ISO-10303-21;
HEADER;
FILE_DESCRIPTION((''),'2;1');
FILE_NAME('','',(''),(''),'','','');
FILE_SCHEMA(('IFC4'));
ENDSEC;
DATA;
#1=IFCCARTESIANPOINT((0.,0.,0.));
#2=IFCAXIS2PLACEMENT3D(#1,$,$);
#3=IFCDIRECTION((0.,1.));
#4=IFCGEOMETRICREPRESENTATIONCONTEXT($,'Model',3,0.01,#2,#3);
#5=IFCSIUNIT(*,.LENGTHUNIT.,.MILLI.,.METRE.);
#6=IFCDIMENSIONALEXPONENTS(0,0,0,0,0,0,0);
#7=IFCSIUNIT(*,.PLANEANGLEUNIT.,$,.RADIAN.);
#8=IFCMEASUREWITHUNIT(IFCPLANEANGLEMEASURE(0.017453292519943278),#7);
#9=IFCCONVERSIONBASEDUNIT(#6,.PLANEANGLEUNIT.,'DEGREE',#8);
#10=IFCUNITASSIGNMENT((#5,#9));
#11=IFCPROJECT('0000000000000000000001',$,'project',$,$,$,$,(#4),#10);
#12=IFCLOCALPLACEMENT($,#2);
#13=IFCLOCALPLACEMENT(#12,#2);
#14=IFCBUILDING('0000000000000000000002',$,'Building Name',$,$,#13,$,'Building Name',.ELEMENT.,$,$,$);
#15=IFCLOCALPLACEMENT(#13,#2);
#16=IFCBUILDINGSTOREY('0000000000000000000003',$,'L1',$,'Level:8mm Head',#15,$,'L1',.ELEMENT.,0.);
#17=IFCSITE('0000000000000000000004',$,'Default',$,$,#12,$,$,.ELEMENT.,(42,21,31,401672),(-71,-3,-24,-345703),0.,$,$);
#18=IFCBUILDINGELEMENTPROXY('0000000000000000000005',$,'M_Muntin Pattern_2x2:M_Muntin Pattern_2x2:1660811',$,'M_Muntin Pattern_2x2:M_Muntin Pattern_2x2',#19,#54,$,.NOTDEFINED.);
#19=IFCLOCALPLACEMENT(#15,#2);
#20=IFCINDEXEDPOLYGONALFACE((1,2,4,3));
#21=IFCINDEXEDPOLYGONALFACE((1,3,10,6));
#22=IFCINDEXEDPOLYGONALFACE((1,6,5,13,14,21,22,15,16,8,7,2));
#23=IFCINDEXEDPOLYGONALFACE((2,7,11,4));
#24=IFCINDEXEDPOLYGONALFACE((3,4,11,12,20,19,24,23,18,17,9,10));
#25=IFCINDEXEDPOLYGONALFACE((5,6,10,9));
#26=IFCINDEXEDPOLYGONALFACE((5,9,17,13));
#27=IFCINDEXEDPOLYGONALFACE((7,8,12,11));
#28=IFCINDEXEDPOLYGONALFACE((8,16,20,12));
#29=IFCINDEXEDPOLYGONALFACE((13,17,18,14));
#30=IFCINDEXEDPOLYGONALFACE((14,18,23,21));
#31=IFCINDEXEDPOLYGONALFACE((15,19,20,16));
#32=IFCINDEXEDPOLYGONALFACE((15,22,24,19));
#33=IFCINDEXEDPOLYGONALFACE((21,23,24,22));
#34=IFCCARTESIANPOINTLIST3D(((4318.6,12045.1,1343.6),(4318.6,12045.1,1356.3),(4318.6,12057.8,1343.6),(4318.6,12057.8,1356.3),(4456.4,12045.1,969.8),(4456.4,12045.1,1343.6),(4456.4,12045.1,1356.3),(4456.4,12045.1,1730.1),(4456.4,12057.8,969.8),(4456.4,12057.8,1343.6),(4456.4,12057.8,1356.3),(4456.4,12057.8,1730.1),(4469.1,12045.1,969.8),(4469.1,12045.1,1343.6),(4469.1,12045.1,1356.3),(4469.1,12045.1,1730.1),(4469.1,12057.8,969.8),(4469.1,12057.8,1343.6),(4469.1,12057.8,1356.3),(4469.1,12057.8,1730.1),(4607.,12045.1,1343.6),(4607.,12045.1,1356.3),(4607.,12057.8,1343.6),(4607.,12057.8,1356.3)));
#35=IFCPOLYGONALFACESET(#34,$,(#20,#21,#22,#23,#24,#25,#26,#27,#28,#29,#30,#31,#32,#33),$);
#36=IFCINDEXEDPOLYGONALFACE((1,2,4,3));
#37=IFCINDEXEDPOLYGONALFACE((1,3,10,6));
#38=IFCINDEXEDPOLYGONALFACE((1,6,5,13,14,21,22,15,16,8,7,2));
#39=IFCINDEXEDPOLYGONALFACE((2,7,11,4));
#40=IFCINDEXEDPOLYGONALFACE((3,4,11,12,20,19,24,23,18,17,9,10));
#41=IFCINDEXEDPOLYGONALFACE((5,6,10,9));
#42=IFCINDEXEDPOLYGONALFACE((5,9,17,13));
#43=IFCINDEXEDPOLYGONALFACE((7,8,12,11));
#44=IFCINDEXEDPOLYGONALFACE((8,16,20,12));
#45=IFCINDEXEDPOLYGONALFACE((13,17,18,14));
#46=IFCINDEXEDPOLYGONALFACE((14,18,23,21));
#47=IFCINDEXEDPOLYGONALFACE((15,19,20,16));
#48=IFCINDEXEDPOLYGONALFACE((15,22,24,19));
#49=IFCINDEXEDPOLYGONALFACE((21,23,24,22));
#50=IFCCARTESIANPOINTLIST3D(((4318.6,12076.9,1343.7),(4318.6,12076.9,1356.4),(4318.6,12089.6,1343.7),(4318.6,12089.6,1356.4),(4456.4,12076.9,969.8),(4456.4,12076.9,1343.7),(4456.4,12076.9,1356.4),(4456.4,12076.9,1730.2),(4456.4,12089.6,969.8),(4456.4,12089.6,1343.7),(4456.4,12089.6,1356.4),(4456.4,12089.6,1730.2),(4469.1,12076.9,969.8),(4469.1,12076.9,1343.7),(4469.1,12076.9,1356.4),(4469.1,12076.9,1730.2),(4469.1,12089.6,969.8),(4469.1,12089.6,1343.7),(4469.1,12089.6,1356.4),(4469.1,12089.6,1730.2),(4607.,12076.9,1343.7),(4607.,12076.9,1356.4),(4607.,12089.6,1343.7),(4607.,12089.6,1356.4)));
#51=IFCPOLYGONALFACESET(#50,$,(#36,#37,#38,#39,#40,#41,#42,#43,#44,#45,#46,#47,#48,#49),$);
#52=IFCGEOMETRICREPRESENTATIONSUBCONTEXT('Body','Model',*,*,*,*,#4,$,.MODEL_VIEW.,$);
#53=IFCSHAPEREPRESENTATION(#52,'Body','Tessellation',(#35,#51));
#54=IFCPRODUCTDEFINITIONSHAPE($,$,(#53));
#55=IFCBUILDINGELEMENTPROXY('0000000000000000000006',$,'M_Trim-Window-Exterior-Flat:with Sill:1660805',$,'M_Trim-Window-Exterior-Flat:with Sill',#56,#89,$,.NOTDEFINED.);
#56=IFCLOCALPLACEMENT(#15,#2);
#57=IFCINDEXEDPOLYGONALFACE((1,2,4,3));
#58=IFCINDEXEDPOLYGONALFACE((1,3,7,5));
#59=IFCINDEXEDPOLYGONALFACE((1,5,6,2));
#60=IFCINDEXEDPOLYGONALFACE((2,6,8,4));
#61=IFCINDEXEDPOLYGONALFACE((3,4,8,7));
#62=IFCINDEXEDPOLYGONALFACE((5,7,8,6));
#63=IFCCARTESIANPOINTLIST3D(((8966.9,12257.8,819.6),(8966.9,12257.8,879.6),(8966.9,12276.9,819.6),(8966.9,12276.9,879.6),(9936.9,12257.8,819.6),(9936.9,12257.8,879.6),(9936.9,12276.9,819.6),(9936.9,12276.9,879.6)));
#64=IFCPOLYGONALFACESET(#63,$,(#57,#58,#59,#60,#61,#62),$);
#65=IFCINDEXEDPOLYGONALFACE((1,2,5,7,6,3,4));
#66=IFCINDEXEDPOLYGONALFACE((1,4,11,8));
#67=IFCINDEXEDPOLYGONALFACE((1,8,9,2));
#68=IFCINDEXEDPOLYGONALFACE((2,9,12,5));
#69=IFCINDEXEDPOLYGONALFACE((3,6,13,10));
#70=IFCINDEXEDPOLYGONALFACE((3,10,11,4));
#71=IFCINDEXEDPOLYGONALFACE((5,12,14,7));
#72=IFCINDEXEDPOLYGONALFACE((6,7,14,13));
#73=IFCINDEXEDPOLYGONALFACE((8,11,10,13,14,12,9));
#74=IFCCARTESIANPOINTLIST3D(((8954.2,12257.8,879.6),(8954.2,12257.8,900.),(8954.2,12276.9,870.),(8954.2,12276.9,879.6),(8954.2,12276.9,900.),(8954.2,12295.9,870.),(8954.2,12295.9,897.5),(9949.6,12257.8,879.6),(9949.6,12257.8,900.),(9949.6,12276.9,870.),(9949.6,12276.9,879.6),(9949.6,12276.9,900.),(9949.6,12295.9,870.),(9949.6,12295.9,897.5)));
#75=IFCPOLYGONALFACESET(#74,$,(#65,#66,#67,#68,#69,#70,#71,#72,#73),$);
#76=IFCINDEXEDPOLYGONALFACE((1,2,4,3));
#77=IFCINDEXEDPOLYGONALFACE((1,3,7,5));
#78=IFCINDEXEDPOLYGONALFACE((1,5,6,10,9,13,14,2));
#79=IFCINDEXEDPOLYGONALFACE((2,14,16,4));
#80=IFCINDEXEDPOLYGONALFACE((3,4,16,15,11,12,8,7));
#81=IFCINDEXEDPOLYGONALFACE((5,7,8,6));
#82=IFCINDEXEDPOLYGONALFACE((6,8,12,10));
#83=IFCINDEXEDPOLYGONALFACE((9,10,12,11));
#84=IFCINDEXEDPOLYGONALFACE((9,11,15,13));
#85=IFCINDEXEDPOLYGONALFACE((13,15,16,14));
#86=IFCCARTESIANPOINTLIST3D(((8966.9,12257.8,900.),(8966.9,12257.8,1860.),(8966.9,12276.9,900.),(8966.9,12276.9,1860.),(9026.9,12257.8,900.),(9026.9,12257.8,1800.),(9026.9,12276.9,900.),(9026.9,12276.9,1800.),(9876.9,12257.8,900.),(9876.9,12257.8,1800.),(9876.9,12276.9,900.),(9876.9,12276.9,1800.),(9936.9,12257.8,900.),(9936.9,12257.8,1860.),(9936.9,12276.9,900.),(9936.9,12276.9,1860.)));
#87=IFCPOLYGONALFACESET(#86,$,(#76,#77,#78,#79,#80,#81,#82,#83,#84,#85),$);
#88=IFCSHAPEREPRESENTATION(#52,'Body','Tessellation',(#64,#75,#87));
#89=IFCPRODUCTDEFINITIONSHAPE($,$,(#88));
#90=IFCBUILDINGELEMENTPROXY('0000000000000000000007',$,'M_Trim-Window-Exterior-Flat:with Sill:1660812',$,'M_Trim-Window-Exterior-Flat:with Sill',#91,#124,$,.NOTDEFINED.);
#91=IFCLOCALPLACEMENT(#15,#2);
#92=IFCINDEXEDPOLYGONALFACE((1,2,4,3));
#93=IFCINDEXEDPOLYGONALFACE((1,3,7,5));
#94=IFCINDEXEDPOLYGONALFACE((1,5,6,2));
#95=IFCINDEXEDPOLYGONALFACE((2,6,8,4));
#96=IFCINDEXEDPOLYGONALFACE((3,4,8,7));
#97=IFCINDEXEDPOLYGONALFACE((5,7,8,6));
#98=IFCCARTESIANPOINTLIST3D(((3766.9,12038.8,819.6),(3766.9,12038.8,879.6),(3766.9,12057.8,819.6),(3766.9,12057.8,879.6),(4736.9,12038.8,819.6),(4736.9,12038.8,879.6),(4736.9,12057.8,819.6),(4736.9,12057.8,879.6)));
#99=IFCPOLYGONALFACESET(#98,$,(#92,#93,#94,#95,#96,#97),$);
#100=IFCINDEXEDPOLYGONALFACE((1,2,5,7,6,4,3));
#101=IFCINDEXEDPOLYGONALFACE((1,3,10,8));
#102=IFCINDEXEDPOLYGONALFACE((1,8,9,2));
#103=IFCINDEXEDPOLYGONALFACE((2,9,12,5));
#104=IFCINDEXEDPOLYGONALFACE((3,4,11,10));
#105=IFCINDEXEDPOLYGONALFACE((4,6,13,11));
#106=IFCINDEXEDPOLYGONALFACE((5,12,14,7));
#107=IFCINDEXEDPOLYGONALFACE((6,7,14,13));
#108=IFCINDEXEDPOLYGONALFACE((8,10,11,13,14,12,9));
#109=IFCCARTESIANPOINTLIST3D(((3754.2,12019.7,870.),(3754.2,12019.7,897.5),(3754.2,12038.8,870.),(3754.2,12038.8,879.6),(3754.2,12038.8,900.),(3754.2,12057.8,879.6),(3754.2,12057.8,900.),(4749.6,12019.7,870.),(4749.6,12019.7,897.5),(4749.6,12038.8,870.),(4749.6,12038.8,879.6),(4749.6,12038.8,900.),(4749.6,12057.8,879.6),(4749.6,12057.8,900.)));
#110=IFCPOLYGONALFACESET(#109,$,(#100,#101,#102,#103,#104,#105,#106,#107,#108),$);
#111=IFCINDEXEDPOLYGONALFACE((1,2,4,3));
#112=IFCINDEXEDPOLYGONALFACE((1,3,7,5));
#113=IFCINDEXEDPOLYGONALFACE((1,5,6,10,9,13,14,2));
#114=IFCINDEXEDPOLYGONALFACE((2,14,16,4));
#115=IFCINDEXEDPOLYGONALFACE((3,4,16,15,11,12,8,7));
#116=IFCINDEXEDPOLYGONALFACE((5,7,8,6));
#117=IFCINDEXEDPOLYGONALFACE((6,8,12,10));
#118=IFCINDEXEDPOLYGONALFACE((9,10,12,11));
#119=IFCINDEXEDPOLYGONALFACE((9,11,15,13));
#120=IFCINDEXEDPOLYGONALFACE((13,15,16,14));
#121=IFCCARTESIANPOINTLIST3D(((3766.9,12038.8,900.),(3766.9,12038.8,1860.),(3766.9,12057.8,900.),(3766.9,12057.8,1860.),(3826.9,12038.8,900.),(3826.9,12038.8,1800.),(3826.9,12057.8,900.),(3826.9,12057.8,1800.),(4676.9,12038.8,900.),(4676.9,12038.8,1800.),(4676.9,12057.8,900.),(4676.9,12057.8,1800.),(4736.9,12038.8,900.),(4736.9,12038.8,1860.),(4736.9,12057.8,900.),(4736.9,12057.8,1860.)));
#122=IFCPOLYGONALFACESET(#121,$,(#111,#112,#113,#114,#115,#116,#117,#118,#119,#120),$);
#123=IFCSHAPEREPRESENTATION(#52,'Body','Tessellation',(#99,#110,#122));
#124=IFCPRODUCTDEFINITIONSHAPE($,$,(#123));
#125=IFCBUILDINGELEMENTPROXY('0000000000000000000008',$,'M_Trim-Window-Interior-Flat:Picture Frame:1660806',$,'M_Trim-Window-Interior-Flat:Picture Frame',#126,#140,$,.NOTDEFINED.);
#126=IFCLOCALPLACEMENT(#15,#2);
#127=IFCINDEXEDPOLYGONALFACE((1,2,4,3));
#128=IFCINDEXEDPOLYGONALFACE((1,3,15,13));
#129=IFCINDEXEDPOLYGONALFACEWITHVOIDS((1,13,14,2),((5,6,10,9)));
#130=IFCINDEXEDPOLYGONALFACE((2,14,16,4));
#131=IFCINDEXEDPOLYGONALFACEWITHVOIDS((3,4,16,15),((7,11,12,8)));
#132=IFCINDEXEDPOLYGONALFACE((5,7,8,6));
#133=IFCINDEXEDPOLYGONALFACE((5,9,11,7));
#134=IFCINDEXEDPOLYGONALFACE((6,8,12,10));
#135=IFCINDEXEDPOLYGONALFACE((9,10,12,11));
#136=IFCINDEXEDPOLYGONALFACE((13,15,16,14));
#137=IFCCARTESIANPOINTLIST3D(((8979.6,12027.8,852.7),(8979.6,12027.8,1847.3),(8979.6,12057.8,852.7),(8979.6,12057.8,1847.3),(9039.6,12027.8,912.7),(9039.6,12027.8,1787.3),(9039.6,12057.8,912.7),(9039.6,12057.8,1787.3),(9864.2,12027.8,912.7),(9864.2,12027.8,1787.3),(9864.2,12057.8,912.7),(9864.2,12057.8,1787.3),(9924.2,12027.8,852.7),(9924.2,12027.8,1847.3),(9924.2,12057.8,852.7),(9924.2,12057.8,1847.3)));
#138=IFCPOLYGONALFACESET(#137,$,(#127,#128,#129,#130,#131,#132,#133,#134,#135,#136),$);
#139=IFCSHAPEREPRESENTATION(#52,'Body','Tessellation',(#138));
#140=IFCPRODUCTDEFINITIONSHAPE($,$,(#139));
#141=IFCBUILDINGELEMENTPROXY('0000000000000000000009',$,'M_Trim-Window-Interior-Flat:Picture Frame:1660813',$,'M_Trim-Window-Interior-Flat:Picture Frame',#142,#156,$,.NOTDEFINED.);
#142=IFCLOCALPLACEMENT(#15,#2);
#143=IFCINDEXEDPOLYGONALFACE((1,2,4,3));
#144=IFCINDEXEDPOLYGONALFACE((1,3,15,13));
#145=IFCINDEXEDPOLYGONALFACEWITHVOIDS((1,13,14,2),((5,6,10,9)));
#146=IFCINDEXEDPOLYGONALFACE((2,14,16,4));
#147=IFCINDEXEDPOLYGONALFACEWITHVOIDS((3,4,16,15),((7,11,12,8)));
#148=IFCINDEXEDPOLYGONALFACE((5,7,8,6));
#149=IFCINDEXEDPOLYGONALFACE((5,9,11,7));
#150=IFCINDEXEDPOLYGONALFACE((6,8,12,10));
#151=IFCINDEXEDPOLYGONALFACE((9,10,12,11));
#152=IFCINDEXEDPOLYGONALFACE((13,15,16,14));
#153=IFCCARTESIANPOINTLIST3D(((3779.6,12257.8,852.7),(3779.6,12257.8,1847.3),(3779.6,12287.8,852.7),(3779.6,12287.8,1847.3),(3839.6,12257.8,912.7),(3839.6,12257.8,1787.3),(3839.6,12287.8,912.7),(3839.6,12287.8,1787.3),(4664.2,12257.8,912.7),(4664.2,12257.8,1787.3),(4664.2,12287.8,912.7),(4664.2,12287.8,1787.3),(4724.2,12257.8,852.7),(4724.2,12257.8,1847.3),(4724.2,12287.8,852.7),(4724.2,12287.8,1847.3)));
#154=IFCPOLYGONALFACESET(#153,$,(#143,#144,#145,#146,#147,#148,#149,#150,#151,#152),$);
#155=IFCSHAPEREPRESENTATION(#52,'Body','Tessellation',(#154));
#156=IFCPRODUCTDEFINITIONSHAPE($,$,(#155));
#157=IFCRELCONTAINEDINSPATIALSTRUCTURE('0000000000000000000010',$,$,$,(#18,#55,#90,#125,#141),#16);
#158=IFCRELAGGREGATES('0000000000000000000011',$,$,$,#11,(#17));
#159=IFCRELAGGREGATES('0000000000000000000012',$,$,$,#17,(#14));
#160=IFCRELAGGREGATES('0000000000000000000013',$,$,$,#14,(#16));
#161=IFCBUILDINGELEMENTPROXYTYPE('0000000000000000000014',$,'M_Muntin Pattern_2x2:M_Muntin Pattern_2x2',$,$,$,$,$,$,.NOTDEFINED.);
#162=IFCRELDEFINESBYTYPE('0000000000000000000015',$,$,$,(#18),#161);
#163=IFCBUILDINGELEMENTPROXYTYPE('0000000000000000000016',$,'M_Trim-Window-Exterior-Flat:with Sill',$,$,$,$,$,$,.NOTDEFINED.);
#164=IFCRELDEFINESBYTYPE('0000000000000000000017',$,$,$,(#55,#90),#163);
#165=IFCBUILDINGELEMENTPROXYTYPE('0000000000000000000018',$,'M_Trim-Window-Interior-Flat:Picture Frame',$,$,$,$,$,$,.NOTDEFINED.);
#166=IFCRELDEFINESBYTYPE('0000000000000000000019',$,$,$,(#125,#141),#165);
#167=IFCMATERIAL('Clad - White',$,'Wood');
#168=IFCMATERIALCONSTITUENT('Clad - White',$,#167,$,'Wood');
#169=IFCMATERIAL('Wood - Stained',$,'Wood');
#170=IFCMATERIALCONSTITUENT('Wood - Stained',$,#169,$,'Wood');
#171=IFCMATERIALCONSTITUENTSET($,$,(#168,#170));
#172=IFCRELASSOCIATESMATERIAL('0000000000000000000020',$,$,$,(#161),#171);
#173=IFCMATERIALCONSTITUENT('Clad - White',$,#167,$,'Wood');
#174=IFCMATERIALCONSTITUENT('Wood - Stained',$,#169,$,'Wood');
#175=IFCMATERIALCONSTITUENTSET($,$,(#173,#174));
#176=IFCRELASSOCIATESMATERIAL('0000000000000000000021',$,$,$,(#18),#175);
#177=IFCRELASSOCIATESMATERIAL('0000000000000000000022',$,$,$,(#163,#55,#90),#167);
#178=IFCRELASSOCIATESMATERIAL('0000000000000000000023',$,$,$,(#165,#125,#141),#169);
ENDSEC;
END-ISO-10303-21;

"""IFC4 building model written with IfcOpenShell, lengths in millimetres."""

from ifc_helpers import new_model, entity, si_unit, converted_unit, direction, frame, origin, place, context, subcontext, project, spatial, indexed_curve, outline, extrude, source, transform, mapped, material, constituent, constituent_set, type_object, type_shapes, element, save


model = new_model("IFC4")

# Units and contexts
model_context = context("Model", 3, precision=0.01, world=origin(), true_north=direction((0.0, 1.0)))
body_context = subcontext(model_context, "Body", "Model", "MODEL_VIEW")
ifc_project = project(units=[si_unit("LENGTHUNIT", "METRE", prefix="MILLI"), converted_unit("PLANEANGLEUNIT", "DEGREE", entity("IfcPlaneAngleMeasure", 0.017453292519943278), si_unit("PLANEANGLEUNIT", "RADIAN"), dimensions=[0, 0, 0, 0, 0, 0, 0])], contexts=[model_context])

# Site, building, storey
site_placement = place(None, origin())
site = spatial("IfcSite", under=ifc_project, at=site_placement, Name="Default", CompositionType="ELEMENT", RefLatitude=(42, 21, 31, 401672), RefLongitude=(-71, -3, -24, -345703), RefElevation=0.0)
building_placement = place(site_placement, origin())
building = spatial("IfcBuilding", under=site, at=building_placement, Name="Building Name", LongName="Building Name", CompositionType="ELEMENT")
storey_placement = place(building_placement, origin())
storey = spatial("IfcBuildingStorey", under=building, at=storey_placement, Name="L1", ObjectType="Level:8mm Head", LongName="L1", CompositionType="ELEMENT", Elevation=0.0)

# Building element proxies
ifc_material_1 = material(Name="Clad - White", Category="Wood")
ifc_material_2 = material(Name="Wood - Stained", Category="Wood")
ifc_constituent_1 = constituent(ifc_material_1, Name="Clad - White", Category="Wood")
ifc_constituent_2 = constituent(ifc_material_2, Name="Wood - Stained", Category="Wood")
ifc_constituent_set_1 = constituent_set(constituents=[ifc_constituent_1, ifc_constituent_2])
building_element_proxy_type_1 = type_object("IfcBuildingElementProxyType", Name="M_Muntin Pattern_2x2:M_Muntin Pattern_2x2", PredefinedType="NOTDEFINED", material=ifc_constituent_set_1)
shared_shape_1 = source(origin(), body_context, "Body", "SweptSolid", [
    extrude(outline(indexed_curve([(6.4, -6.4), (380.1, -6.4), (380.1, 6.3), (6.4, 6.3), (6.4, 144.2), (-6.3, 144.2), (-6.3, 6.3), (-380.2, 6.3), (-380.2, -6.4), (-6.3, -6.4), (-6.3, -144.2), (6.4, -144.2), (6.4, -6.4)], self_intersect=False)), frame((0.0, 9.5, 380.1), z_axis=(0.0, 1.0, 0.0), x_axis=(0.0, 0.0, 1.0)), (0.0, 0.0, 1.0), 12.7),
    extrude(outline(indexed_curve([(6.4, -6.4), (380.2, -6.4), (380.2, 6.3), (6.4, 6.3), (6.4, 144.2), (-6.3, 144.2), (-6.3, 6.3), (-380.2, 6.3), (-380.2, -6.4), (-6.3, -6.4), (-6.3, -144.2), (6.4, -144.2), (6.4, -6.4)], self_intersect=False)), frame((0.0, -22.2, 380.2), z_axis=(0.0, 1.0, 0.0), x_axis=(0.0, 0.0, 1.0)), (0.0, 0.0, 1.0), 12.7),
])
type_shapes(building_element_proxy_type_1, [shared_shape_1])
ifc_constituent_3 = constituent(ifc_material_1, Name="Clad - White", Category="Wood")
ifc_constituent_4 = constituent(ifc_material_2, Name="Wood - Stained", Category="Wood")
ifc_constituent_set_2 = constituent_set(constituents=[ifc_constituent_3, ifc_constituent_4])
proxy_1_placement = place(storey_placement, frame((4462.8, 12067.3, 969.8), z_axis=(0.0, 0.0, 1.0), x_axis=(-1.0, 0.0, 0.0)))
element("IfcBuildingElementProxy", 1, at=proxy_1_placement, inside=storey, type_object=building_element_proxy_type_1, material=ifc_constituent_set_2, Name="M_Muntin Pattern_2x2:M_Muntin Pattern_2x2:1660811", ObjectType="M_Muntin Pattern_2x2:M_Muntin Pattern_2x2", PredefinedType="NOTDEFINED", context=body_context, shape_type="MappedRepresentation", body=[
    mapped(shared_shape_1, transform((0.0, 0.0, 0.0), scale=1.0)),
])
building_element_proxy_type_2 = type_object("IfcBuildingElementProxyType", Name="M_Trim-Window-Exterior-Flat:with Sill", PredefinedType="NOTDEFINED", material=ifc_material_1)
shared_shape_2 = source(origin(), body_context, "Body", "SweptSolid", [
    extrude(outline(indexed_curve([(-485.0, -30.0), (485.0, -30.0), (485.0, 30.0), (-485.0, 30.0), (-485.0, -30.0)], self_intersect=False)), frame((0.0, -950.4, 0.0), z_axis=(0.0, 0.0, 1.0), x_axis=(-1.0, 0.0, 0.0)), (0.0, 0.0, 1.0), 19.0),
    extrude(outline(indexed_curve([(-19.0, -15.2), (0.0, -15.2), (0.0, -5.7), (19.0, -5.7), (19.0, 14.8), (0.0, 14.8), (-19.0, 12.3), (-19.0, -15.2)], self_intersect=False)), frame((-497.7, -914.8, 19.0), z_axis=(1.0, 0.0, 0.0), x_axis=(0.0, 0.0, -1.0)), (0.0, 0.0, 1.0), 995.4),
    extrude(outline(indexed_curve([(-495.0, -485.0), (465.0, -485.0), (465.0, -425.0), (-435.0, -425.0), (-435.0, 425.0), (465.0, 425.0), (465.0, 485.0), (-495.0, 485.0), (-495.0, -485.0)], self_intersect=False)), frame((0.0, -435.0, 0.0), z_axis=(0.0, 0.0, 1.0), x_axis=(0.0, -1.0, 0.0)), (0.0, 0.0, 1.0), 19.0),
])
type_shapes(building_element_proxy_type_2, [shared_shape_2])
for number, where, z_axis, x_axis, name in (
    (2, (9451.9, 12257.8, 1800.0), (0.0, 1.0, 0.0), (-1.0, 0.0, 0.0), "M_Trim-Window-Exterior-Flat:with Sill:1660805"),
    (3, (4251.9, 12057.8, 1800.0), (0.0, -1.0, 0.0), (1.0, 0.0, 0.0), "M_Trim-Window-Exterior-Flat:with Sill:1660812"),
):
    element("IfcBuildingElementProxy", number, at=place(storey_placement, frame(where, z_axis=z_axis, x_axis=x_axis)), inside=storey, type_object=building_element_proxy_type_2, material=ifc_material_1, Name=name, ObjectType="M_Trim-Window-Exterior-Flat:with Sill", PredefinedType="NOTDEFINED", context=body_context, shape_type="MappedRepresentation", body=[
        mapped(shared_shape_2, transform((0.0, 0.0, 0.0), scale=1.0)),
    ])
building_element_proxy_type_3 = type_object("IfcBuildingElementProxyType", Name="M_Trim-Window-Interior-Flat:Picture Frame", PredefinedType="NOTDEFINED", material=ifc_material_2)
shared_shape_3 = source(origin(), body_context, "Body", "SweptSolid", [
    extrude(outline(indexed_curve([(-472.3, -497.3), (472.3, -497.3), (472.3, 497.3), (-472.3, 497.3), (-472.3, -497.3)], self_intersect=False), holes=[indexed_curve([(-412.3, -437.3), (-412.3, 437.3), (412.3, 437.3), (412.3, -437.3), (-412.3, -437.3)], self_intersect=False)]), frame((0.0, -450.0, 0.0), z_axis=(0.0, 0.0, 1.0), x_axis=(-1.0, 0.0, 0.0)), (0.0, 0.0, 1.0), 30.0),
])
type_shapes(building_element_proxy_type_3, [shared_shape_3])
for number, where, z_axis, x_axis, name in (
    (4, (9451.9, 12057.8, 1800.0), (0.0, -1.0, 0.0), (1.0, 0.0, 0.0), "M_Trim-Window-Interior-Flat:Picture Frame:1660806"),
    (5, (4251.9, 12257.8, 1800.0), (0.0, 1.0, 0.0), (-1.0, 0.0, 0.0), "M_Trim-Window-Interior-Flat:Picture Frame:1660813"),
):
    element("IfcBuildingElementProxy", number, at=place(storey_placement, frame(where, z_axis=z_axis, x_axis=x_axis)), inside=storey, type_object=building_element_proxy_type_3, material=ifc_material_2, Name=name, ObjectType="M_Trim-Window-Interior-Flat:Picture Frame", PredefinedType="NOTDEFINED", context=body_context, shape_type="MappedRepresentation", body=[
        mapped(shared_shape_3, transform((0.0, 0.0, 0.0), scale=1.0)),
    ])

save(model, "model.ifc")
